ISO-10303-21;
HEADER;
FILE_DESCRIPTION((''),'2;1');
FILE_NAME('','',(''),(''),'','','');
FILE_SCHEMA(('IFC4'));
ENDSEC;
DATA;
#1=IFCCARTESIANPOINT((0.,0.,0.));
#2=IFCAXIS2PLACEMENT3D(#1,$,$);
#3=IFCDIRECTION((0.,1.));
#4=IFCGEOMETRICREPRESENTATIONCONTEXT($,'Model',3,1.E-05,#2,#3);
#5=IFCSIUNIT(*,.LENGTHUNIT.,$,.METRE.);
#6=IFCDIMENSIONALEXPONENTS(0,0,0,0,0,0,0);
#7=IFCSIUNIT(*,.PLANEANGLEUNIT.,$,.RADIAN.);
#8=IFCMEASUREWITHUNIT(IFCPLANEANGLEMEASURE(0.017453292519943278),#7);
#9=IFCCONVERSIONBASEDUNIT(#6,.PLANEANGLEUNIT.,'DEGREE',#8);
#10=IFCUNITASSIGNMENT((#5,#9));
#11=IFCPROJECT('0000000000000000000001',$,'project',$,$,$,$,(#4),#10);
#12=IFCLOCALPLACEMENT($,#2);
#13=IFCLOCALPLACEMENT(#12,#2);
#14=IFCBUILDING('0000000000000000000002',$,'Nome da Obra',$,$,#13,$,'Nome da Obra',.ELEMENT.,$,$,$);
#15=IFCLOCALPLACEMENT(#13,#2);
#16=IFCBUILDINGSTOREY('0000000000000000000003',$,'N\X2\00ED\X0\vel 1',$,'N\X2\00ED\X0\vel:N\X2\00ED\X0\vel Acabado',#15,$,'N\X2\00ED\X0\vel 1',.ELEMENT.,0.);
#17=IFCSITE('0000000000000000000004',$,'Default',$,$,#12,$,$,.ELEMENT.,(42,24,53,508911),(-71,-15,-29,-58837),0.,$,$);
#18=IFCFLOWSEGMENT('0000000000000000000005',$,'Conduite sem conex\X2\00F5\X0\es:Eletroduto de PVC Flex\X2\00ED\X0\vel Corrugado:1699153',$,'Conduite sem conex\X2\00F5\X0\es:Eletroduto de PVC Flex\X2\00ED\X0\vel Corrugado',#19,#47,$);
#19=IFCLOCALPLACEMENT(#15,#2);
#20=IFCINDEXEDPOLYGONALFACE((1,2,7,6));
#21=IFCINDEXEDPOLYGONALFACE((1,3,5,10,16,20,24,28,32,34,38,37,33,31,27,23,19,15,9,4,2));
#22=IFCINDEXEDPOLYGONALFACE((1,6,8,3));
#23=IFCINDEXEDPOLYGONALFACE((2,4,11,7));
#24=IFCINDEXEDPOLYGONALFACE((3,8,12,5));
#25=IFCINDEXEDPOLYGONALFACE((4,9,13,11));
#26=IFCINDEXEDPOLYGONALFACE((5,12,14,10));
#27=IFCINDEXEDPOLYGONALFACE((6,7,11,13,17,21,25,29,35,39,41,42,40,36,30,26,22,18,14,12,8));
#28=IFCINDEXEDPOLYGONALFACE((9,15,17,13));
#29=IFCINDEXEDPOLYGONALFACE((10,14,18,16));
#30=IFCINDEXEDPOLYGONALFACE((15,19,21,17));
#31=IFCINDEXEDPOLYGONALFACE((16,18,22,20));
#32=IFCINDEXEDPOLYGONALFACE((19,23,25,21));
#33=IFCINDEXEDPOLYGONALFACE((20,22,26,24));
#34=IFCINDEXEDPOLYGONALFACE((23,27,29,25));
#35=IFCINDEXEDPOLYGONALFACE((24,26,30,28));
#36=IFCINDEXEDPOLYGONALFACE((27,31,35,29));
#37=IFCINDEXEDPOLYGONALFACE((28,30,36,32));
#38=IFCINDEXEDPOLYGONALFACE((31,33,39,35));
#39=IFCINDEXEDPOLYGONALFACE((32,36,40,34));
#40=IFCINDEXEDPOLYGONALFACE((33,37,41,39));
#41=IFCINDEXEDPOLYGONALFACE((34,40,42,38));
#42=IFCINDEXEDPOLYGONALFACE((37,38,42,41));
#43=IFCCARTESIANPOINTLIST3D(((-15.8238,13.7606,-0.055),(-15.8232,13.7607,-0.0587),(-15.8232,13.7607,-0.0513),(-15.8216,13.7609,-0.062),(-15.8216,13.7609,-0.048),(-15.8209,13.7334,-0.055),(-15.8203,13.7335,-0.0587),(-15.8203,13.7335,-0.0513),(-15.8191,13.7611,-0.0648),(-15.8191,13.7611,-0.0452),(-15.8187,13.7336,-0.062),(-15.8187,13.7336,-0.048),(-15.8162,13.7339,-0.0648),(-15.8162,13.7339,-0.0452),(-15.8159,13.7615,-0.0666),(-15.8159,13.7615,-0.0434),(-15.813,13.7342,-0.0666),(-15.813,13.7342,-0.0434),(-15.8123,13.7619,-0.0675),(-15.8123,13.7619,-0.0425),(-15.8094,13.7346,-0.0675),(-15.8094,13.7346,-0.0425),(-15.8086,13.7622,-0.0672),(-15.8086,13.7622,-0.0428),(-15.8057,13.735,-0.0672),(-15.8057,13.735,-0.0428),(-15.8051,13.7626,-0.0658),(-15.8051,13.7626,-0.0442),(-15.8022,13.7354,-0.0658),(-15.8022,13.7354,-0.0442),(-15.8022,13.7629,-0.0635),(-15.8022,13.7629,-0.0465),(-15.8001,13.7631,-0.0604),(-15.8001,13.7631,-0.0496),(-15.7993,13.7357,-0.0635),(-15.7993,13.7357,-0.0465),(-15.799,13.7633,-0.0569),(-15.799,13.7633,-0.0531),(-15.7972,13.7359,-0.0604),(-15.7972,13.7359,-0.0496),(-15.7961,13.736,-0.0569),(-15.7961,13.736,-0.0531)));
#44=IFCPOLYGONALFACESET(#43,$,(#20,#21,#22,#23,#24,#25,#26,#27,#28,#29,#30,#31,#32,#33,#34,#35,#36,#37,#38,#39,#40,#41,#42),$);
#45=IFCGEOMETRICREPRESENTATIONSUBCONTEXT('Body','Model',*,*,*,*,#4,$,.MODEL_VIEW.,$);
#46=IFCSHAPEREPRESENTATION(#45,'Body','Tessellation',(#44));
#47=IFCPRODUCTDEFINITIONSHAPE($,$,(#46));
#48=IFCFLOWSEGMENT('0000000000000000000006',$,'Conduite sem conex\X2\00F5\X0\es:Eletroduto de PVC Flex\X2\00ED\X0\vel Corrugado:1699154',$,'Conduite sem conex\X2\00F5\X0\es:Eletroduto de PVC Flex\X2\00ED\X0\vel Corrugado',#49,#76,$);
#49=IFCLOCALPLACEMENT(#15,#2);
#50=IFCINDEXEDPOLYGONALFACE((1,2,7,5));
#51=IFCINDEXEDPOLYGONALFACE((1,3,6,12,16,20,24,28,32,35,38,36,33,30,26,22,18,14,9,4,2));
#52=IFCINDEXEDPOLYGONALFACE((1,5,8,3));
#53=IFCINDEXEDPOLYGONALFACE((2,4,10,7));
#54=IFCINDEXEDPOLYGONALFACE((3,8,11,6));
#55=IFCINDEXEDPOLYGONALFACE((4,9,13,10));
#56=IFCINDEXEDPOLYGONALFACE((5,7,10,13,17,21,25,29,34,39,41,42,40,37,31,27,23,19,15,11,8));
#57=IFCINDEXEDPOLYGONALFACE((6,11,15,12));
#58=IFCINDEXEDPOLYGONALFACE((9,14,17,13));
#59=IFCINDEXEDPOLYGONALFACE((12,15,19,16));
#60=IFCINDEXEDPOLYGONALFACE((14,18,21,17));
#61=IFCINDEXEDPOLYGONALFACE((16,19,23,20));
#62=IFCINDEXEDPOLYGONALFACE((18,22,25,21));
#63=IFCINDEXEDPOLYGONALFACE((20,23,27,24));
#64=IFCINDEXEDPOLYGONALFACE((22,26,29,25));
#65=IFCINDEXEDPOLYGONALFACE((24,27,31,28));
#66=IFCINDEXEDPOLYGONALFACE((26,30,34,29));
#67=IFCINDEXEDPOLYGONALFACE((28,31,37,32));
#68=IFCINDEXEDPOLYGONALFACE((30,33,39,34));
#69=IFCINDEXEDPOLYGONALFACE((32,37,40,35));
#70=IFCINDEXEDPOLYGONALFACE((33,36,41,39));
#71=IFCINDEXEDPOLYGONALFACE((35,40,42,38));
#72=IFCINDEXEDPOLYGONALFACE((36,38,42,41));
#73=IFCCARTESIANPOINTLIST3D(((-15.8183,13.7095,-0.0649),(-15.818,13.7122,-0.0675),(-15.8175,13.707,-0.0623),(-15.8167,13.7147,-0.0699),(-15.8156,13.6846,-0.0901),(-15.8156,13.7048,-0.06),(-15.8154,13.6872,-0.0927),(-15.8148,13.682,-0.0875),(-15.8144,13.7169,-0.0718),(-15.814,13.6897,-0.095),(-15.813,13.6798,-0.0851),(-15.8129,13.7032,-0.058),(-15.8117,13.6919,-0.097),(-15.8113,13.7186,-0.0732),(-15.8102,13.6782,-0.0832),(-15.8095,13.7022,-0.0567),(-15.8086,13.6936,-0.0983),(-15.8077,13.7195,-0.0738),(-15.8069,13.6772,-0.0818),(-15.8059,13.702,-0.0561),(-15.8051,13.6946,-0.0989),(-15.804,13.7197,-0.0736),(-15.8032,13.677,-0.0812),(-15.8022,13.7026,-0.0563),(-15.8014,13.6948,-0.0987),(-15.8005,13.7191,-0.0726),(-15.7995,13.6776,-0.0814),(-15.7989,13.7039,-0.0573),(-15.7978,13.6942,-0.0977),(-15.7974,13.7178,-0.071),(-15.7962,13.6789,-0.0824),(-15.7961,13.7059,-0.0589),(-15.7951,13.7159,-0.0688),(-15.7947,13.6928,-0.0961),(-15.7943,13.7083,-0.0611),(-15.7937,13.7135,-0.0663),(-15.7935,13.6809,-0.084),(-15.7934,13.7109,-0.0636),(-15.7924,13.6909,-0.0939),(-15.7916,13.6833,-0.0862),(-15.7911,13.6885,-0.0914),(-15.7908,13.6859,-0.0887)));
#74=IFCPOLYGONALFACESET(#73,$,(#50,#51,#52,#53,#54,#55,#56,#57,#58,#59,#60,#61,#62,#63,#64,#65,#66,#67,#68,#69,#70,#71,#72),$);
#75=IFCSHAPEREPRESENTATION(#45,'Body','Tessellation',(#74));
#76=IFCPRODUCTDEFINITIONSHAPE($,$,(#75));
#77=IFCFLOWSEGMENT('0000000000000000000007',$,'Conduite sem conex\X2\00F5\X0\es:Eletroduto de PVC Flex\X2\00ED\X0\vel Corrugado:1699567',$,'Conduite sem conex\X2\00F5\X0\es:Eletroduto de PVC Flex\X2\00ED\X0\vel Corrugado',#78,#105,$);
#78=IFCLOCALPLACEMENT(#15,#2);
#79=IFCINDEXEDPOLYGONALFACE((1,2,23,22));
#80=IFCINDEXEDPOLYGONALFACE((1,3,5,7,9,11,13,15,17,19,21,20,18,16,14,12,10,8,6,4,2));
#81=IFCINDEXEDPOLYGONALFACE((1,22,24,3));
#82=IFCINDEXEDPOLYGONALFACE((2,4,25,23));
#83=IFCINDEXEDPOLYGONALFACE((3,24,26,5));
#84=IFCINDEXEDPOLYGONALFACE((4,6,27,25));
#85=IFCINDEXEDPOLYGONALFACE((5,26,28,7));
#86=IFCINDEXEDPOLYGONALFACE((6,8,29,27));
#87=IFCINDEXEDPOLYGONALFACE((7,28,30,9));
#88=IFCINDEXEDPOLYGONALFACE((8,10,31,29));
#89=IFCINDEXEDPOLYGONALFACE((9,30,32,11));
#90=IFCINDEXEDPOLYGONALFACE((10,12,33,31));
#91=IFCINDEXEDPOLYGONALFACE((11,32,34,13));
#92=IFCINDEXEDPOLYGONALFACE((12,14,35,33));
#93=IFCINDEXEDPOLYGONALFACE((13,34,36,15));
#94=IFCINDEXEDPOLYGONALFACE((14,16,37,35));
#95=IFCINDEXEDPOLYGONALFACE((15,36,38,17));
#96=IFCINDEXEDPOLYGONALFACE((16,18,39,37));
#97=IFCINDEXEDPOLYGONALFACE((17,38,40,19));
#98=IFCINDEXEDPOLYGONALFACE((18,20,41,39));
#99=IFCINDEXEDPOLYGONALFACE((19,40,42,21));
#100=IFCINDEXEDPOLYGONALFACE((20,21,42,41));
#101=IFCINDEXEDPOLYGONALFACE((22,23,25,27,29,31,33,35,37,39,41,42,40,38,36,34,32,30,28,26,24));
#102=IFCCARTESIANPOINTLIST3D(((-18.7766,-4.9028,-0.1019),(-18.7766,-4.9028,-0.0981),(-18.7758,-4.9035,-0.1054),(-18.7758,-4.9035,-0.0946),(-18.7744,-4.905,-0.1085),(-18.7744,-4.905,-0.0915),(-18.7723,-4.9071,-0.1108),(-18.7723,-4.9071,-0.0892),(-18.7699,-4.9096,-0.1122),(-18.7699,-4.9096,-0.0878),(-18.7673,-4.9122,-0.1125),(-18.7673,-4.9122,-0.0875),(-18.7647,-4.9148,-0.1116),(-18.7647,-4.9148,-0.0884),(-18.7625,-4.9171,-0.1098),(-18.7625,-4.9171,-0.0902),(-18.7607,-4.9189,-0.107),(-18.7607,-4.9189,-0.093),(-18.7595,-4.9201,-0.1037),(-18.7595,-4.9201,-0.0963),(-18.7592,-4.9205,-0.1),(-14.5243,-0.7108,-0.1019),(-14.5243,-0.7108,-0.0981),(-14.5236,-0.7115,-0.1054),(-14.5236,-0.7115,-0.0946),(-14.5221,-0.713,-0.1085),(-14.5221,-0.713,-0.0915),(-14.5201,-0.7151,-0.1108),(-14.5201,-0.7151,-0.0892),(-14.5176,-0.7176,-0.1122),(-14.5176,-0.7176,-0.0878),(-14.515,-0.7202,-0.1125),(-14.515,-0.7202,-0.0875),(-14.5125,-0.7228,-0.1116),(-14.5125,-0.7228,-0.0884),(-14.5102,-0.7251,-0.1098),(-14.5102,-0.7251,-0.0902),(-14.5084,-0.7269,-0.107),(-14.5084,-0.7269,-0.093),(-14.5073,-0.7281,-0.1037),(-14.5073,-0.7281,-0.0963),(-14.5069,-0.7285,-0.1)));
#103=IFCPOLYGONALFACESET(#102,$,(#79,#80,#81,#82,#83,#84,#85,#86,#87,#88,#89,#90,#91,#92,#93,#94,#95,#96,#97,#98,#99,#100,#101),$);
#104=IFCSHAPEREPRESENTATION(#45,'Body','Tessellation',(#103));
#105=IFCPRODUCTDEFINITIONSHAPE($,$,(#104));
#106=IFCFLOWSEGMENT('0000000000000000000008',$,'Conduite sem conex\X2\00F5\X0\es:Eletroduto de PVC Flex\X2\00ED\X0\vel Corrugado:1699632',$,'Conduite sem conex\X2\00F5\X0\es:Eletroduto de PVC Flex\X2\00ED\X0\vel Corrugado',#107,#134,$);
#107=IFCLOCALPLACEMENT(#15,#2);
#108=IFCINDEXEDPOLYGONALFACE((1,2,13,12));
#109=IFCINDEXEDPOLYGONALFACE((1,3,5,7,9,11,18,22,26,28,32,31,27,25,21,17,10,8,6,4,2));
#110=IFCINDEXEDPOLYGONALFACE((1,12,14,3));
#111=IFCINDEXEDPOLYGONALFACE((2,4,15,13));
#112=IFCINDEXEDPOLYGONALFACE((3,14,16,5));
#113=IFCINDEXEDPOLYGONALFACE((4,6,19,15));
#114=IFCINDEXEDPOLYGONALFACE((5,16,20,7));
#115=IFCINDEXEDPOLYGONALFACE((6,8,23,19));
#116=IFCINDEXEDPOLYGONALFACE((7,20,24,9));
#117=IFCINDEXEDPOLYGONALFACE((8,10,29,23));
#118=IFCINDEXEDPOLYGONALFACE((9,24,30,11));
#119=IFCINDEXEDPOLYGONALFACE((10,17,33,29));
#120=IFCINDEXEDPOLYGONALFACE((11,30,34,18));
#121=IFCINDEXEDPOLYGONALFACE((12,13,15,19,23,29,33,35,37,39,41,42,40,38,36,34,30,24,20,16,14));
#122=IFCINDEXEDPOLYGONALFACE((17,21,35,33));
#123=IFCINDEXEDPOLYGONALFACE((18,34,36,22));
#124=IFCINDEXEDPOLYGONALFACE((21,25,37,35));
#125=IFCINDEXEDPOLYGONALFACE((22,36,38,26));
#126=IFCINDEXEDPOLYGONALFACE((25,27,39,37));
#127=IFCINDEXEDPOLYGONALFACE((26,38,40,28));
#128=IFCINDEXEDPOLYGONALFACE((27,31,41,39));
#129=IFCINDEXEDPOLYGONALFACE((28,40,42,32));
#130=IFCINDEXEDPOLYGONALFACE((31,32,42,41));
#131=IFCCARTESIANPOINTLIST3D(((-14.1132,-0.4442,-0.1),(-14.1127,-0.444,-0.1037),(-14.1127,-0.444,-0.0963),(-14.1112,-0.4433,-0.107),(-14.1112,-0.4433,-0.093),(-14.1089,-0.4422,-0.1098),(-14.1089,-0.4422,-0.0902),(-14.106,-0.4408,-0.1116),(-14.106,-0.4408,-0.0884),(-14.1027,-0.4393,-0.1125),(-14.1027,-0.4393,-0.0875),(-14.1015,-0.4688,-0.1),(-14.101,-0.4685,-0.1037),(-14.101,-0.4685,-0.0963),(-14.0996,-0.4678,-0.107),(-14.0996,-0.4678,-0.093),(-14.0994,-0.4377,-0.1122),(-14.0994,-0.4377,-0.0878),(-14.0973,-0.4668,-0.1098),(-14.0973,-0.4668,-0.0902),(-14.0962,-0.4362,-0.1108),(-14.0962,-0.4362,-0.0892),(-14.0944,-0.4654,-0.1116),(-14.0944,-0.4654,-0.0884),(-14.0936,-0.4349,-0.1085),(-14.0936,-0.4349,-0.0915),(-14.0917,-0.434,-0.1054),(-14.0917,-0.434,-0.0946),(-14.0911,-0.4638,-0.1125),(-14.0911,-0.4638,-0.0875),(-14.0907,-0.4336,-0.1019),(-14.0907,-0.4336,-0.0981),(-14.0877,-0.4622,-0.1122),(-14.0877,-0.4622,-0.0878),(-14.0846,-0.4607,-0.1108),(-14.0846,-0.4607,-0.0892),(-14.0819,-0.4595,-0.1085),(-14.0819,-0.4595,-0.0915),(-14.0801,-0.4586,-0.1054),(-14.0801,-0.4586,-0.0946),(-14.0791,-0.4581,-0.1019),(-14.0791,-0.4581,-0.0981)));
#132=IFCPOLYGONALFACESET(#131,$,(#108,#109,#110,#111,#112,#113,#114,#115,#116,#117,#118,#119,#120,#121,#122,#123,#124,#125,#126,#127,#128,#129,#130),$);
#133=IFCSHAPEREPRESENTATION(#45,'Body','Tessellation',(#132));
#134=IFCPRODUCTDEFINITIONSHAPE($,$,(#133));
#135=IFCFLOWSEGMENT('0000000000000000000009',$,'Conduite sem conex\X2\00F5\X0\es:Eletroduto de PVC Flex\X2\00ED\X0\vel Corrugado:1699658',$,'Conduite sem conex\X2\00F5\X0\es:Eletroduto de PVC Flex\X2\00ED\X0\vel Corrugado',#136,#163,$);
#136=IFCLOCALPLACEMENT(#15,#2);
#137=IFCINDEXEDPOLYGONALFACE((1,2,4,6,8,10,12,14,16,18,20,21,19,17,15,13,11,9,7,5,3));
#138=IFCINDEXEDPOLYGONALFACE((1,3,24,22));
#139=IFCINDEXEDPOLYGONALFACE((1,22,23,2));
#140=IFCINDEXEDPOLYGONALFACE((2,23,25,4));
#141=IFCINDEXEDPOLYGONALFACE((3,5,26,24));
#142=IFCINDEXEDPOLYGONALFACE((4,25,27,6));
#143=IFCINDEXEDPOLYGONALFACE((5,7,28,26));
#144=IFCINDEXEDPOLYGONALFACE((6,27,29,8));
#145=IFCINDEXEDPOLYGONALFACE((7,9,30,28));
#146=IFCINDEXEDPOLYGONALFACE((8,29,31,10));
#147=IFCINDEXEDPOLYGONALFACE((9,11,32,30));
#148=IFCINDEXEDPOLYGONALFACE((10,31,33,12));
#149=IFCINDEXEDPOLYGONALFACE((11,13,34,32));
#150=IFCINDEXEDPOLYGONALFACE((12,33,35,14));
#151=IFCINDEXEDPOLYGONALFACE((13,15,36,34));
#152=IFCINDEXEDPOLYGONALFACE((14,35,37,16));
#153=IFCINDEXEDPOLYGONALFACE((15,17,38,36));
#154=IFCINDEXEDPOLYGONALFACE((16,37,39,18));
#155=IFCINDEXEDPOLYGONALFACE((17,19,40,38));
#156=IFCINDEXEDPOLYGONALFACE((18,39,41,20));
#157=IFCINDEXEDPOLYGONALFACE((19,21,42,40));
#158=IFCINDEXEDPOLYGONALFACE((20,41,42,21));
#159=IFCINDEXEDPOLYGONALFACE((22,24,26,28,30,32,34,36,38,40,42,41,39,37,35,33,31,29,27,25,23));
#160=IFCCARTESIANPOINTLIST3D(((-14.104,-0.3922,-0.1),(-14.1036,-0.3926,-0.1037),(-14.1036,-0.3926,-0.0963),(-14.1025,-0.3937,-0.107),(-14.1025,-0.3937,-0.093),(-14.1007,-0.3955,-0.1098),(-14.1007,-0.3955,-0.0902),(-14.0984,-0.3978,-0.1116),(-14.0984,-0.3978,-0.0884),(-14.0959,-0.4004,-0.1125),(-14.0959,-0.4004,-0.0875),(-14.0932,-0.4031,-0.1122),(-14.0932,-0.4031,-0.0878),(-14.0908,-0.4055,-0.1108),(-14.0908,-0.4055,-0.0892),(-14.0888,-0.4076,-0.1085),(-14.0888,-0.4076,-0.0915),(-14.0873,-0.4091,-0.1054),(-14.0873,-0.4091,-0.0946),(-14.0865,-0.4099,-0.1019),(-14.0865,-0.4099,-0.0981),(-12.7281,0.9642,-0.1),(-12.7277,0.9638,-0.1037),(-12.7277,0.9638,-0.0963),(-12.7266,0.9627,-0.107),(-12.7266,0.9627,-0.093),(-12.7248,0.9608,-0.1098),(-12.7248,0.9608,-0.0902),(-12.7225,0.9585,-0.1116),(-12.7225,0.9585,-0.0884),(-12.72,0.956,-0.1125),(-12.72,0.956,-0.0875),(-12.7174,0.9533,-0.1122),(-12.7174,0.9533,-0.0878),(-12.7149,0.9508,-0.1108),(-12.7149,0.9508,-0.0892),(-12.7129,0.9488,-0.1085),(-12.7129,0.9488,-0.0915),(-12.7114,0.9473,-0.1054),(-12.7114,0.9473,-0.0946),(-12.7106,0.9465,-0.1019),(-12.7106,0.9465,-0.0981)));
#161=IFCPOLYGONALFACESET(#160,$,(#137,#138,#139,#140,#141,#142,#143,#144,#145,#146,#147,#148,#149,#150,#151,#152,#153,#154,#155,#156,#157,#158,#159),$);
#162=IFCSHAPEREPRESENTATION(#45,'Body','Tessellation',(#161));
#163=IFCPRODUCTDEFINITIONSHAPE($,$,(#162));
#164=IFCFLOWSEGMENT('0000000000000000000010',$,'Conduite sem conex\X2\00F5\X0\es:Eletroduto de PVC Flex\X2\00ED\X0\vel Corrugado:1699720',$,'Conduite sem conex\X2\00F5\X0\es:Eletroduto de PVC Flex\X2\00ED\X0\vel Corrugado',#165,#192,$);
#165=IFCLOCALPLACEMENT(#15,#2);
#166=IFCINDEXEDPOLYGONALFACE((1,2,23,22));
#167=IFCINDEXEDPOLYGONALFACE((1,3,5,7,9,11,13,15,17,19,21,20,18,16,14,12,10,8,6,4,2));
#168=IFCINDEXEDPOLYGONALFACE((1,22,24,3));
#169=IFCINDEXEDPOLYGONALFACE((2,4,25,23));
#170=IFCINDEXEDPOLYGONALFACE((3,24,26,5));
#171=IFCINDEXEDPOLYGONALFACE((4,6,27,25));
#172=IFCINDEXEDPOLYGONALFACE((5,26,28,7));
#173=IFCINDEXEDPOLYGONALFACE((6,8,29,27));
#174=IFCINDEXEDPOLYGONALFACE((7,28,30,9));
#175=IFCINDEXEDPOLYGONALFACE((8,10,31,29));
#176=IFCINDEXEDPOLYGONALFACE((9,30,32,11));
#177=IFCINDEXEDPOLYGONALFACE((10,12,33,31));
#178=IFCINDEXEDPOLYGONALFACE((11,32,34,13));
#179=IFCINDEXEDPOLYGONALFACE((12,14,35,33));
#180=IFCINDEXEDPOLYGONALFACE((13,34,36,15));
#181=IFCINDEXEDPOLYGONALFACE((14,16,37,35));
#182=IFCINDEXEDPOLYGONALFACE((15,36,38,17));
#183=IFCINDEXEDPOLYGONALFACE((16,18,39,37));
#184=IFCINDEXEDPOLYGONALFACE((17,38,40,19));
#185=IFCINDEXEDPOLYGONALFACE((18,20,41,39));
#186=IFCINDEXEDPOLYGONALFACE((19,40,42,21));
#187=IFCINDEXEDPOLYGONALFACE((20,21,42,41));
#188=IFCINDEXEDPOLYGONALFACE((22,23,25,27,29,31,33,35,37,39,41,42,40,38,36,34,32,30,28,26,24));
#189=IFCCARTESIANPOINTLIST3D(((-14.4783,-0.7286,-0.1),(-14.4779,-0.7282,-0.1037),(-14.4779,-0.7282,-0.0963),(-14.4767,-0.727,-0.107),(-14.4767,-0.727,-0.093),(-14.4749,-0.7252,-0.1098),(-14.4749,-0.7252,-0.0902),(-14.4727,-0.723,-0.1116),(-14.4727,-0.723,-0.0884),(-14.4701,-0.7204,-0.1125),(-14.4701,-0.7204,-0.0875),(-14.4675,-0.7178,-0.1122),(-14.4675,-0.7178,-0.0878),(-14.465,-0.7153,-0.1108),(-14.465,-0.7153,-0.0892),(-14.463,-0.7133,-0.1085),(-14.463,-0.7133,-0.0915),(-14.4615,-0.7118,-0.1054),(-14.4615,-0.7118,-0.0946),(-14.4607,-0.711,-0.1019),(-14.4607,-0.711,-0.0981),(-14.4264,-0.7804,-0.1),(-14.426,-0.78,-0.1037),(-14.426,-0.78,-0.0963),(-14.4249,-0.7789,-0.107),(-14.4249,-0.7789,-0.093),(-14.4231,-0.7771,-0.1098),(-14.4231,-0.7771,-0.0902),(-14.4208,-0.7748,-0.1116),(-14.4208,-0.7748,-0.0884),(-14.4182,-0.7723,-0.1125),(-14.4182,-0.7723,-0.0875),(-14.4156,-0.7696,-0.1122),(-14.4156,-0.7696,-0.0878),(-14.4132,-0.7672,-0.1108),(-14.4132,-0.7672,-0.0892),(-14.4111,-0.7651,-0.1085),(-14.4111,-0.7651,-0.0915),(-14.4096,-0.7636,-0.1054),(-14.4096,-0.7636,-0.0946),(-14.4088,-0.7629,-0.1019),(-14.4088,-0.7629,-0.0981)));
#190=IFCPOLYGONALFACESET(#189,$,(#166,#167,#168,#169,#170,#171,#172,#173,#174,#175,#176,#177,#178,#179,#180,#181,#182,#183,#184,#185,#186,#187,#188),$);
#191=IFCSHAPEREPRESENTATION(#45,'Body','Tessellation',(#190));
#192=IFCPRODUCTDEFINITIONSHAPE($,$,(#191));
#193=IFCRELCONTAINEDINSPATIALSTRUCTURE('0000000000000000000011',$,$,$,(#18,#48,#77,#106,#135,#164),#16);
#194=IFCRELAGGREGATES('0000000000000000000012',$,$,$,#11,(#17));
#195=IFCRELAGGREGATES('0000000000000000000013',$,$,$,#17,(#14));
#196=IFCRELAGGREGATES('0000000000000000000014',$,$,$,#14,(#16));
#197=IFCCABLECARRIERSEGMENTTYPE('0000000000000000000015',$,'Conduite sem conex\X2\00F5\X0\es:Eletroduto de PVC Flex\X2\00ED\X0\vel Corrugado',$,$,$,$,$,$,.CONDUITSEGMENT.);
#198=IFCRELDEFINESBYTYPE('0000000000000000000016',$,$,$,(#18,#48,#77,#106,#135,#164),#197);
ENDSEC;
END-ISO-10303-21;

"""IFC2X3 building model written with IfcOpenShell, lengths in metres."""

from ifc_helpers import new_model, entity, si_unit, converted_unit, direction, frame, frame_2d, origin, origin_2d_with_axis, place, context, subcontext, project, spatial, circle, extrude, type_object, element, save


model = new_model("IFC2X3")

# Units and contexts
model_context = context("Model", 3, precision=1e-05, world=origin(), true_north=direction((0.0, 1.0)))
body_context = subcontext(model_context, "Body", "Model", "MODEL_VIEW")
ifc_project = project(units=[si_unit("LENGTHUNIT", "METRE"), converted_unit("PLANEANGLEUNIT", "DEGREE", entity("IfcPlaneAngleMeasure", 0.017453292519943278), si_unit("PLANEANGLEUNIT", "RADIAN"), dimensions=[0, 0, 0, 0, 0, 0, 0])], contexts=[model_context])

# Site, building, storey
site_placement = place(None, origin())
site = spatial("IfcSite", under=ifc_project, at=site_placement, Name="Default", CompositionType="ELEMENT", RefLatitude=(42, 24, 53, 508911), RefLongitude=(-71, -15, -29, -58837), RefElevation=0.0)
building_placement = place(site_placement, origin())
building = spatial("IfcBuilding", under=site, at=building_placement, Name="Nome da Obra", LongName="Nome da Obra", CompositionType="ELEMENT")
storey_placement = place(building_placement, origin())
storey = spatial("IfcBuildingStorey", under=building, at=storey_placement, Name="Nível 1", ObjectType="Nível:Nível Acabado", LongName="Nível 1", CompositionType="ELEMENT", Elevation=0.0)

# Flow segments
cable_carrier_segment_type = type_object("IfcCableCarrierSegmentType", Name="Conduite sem conexões:Eletroduto de PVC Flexível Corrugado", PredefinedType="CONDUITSEGMENT")
flow_segment_1_placement = place(storey_placement, origin())
element("IfcFlowSegment", 1, at=flow_segment_1_placement, inside=storey, type_object=cable_carrier_segment_type, Name="Conduite sem conexões:Eletroduto de PVC Flexível Corrugado:1699153", ObjectType="Conduite sem conexões:Eletroduto de PVC Flexível Corrugado", context=body_context, shape_type="SweptSolid", body=[
    extrude(circle(Radius=0.0125, at=frame_2d((0.0, 0.0), x_axis=(1.0, 0.0))), frame((-15.8113, 13.762, -0.055), z_axis=(0.106176, -0.994347, 0.0), x_axis=(-0.994347, -0.106176, 0.0)), (0.0, 0.0, 1.0), 0.0274),
])
flow_segment_2_placement = place(storey_placement, origin())
element("IfcFlowSegment", 2, at=flow_segment_2_placement, inside=storey, type_object=cable_carrier_segment_type, Name="Conduite sem conexões:Eletroduto de PVC Flexível Corrugado:1699154", ObjectType="Conduite sem conexões:Eletroduto de PVC Flexível Corrugado", context=body_context, shape_type="SweptSolid", body=[
    extrude(circle(Radius=0.0125, at=frame_2d((0.0, 0.0), x_axis=(1.0, 0.0))), frame((-15.8059, 13.7109, -0.0649), z_axis=(0.075078, -0.70311, -0.707107), x_axis=(-0.994347, -0.106176, 0.0)), (0.0, 0.0, 1.0), 0.0355),
])
flow_segment_3_placement = place(storey_placement, origin())
element("IfcFlowSegment", 3, at=flow_segment_3_placement, inside=storey, type_object=cable_carrier_segment_type, Name="Conduite sem conexões:Eletroduto de PVC Flexível Corrugado:1699567", ObjectType="Conduite sem conexões:Eletroduto de PVC Flexível Corrugado", context=body_context, shape_type="SweptSolid", body=[
    extrude(circle(Radius=0.0125, at=origin_2d_with_axis()), frame((-18.7679, -4.9116, -0.1), z_axis=(0.712135, 0.702042, 0.0), x_axis=(0.702042, -0.712135, 0.0)), (0.0, 0.0, 1.0), 5.9711),
])
flow_segment_4_placement = place(storey_placement, origin())
element("IfcFlowSegment", 4, at=flow_segment_4_placement, inside=storey, type_object=cable_carrier_segment_type, Name="Conduite sem conexões:Eletroduto de PVC Flexível Corrugado:1699632", ObjectType="Conduite sem conexões:Eletroduto de PVC Flexível Corrugado", context=body_context, shape_type="SweptSolid", body=[
    extrude(circle(Radius=0.0125, at=frame_2d((0.0, 0.0), x_axis=(1.0, 0.0))), frame((-14.0902, -0.4634, -0.1), z_axis=(-0.428806, 0.903397, 0.0), x_axis=(-0.903397, -0.428806, 0.0)), (0.0, 0.0, 1.0), 0.0272),
])
flow_segment_5_placement = place(storey_placement, origin())
element("IfcFlowSegment", 5, at=flow_segment_5_placement, inside=storey, type_object=cable_carrier_segment_type, Name="Conduite sem conexões:Eletroduto de PVC Flexível Corrugado:1699658", ObjectType="Conduite sem conexões:Eletroduto de PVC Flexível Corrugado", context=body_context, shape_type="SweptSolid", body=[
    extrude(circle(Radius=0.0125, at=frame_2d((0.0, 0.0), x_axis=(1.0, 0.0))), frame((-14.0952, -0.4011, -0.1), z_axis=(0.712135, 0.702042, 0.0), x_axis=(-0.702042, 0.712135, 0.0)), (0.0, 0.0, 1.0), 1.932),
])
flow_segment_6_placement = place(storey_placement, origin())
element("IfcFlowSegment", 6, at=flow_segment_6_placement, inside=storey, type_object=cable_carrier_segment_type, Name="Conduite sem conexões:Eletroduto de PVC Flexível Corrugado:1699720", ObjectType="Conduite sem conexões:Eletroduto de PVC Flexível Corrugado", context=body_context, shape_type="SweptSolid", body=[
    extrude(circle(Radius=0.0125, at=frame_2d((0.0, 0.0), x_axis=(1.0, 0.0))), frame((-14.4694, -0.7197, -0.1), z_axis=(0.707107, -0.707107, 0.0), x_axis=(-0.707107, -0.707107, 0.0)), (0.0, 0.0, 1.0), 0.0733),
])

save(model, "model.ifc")
